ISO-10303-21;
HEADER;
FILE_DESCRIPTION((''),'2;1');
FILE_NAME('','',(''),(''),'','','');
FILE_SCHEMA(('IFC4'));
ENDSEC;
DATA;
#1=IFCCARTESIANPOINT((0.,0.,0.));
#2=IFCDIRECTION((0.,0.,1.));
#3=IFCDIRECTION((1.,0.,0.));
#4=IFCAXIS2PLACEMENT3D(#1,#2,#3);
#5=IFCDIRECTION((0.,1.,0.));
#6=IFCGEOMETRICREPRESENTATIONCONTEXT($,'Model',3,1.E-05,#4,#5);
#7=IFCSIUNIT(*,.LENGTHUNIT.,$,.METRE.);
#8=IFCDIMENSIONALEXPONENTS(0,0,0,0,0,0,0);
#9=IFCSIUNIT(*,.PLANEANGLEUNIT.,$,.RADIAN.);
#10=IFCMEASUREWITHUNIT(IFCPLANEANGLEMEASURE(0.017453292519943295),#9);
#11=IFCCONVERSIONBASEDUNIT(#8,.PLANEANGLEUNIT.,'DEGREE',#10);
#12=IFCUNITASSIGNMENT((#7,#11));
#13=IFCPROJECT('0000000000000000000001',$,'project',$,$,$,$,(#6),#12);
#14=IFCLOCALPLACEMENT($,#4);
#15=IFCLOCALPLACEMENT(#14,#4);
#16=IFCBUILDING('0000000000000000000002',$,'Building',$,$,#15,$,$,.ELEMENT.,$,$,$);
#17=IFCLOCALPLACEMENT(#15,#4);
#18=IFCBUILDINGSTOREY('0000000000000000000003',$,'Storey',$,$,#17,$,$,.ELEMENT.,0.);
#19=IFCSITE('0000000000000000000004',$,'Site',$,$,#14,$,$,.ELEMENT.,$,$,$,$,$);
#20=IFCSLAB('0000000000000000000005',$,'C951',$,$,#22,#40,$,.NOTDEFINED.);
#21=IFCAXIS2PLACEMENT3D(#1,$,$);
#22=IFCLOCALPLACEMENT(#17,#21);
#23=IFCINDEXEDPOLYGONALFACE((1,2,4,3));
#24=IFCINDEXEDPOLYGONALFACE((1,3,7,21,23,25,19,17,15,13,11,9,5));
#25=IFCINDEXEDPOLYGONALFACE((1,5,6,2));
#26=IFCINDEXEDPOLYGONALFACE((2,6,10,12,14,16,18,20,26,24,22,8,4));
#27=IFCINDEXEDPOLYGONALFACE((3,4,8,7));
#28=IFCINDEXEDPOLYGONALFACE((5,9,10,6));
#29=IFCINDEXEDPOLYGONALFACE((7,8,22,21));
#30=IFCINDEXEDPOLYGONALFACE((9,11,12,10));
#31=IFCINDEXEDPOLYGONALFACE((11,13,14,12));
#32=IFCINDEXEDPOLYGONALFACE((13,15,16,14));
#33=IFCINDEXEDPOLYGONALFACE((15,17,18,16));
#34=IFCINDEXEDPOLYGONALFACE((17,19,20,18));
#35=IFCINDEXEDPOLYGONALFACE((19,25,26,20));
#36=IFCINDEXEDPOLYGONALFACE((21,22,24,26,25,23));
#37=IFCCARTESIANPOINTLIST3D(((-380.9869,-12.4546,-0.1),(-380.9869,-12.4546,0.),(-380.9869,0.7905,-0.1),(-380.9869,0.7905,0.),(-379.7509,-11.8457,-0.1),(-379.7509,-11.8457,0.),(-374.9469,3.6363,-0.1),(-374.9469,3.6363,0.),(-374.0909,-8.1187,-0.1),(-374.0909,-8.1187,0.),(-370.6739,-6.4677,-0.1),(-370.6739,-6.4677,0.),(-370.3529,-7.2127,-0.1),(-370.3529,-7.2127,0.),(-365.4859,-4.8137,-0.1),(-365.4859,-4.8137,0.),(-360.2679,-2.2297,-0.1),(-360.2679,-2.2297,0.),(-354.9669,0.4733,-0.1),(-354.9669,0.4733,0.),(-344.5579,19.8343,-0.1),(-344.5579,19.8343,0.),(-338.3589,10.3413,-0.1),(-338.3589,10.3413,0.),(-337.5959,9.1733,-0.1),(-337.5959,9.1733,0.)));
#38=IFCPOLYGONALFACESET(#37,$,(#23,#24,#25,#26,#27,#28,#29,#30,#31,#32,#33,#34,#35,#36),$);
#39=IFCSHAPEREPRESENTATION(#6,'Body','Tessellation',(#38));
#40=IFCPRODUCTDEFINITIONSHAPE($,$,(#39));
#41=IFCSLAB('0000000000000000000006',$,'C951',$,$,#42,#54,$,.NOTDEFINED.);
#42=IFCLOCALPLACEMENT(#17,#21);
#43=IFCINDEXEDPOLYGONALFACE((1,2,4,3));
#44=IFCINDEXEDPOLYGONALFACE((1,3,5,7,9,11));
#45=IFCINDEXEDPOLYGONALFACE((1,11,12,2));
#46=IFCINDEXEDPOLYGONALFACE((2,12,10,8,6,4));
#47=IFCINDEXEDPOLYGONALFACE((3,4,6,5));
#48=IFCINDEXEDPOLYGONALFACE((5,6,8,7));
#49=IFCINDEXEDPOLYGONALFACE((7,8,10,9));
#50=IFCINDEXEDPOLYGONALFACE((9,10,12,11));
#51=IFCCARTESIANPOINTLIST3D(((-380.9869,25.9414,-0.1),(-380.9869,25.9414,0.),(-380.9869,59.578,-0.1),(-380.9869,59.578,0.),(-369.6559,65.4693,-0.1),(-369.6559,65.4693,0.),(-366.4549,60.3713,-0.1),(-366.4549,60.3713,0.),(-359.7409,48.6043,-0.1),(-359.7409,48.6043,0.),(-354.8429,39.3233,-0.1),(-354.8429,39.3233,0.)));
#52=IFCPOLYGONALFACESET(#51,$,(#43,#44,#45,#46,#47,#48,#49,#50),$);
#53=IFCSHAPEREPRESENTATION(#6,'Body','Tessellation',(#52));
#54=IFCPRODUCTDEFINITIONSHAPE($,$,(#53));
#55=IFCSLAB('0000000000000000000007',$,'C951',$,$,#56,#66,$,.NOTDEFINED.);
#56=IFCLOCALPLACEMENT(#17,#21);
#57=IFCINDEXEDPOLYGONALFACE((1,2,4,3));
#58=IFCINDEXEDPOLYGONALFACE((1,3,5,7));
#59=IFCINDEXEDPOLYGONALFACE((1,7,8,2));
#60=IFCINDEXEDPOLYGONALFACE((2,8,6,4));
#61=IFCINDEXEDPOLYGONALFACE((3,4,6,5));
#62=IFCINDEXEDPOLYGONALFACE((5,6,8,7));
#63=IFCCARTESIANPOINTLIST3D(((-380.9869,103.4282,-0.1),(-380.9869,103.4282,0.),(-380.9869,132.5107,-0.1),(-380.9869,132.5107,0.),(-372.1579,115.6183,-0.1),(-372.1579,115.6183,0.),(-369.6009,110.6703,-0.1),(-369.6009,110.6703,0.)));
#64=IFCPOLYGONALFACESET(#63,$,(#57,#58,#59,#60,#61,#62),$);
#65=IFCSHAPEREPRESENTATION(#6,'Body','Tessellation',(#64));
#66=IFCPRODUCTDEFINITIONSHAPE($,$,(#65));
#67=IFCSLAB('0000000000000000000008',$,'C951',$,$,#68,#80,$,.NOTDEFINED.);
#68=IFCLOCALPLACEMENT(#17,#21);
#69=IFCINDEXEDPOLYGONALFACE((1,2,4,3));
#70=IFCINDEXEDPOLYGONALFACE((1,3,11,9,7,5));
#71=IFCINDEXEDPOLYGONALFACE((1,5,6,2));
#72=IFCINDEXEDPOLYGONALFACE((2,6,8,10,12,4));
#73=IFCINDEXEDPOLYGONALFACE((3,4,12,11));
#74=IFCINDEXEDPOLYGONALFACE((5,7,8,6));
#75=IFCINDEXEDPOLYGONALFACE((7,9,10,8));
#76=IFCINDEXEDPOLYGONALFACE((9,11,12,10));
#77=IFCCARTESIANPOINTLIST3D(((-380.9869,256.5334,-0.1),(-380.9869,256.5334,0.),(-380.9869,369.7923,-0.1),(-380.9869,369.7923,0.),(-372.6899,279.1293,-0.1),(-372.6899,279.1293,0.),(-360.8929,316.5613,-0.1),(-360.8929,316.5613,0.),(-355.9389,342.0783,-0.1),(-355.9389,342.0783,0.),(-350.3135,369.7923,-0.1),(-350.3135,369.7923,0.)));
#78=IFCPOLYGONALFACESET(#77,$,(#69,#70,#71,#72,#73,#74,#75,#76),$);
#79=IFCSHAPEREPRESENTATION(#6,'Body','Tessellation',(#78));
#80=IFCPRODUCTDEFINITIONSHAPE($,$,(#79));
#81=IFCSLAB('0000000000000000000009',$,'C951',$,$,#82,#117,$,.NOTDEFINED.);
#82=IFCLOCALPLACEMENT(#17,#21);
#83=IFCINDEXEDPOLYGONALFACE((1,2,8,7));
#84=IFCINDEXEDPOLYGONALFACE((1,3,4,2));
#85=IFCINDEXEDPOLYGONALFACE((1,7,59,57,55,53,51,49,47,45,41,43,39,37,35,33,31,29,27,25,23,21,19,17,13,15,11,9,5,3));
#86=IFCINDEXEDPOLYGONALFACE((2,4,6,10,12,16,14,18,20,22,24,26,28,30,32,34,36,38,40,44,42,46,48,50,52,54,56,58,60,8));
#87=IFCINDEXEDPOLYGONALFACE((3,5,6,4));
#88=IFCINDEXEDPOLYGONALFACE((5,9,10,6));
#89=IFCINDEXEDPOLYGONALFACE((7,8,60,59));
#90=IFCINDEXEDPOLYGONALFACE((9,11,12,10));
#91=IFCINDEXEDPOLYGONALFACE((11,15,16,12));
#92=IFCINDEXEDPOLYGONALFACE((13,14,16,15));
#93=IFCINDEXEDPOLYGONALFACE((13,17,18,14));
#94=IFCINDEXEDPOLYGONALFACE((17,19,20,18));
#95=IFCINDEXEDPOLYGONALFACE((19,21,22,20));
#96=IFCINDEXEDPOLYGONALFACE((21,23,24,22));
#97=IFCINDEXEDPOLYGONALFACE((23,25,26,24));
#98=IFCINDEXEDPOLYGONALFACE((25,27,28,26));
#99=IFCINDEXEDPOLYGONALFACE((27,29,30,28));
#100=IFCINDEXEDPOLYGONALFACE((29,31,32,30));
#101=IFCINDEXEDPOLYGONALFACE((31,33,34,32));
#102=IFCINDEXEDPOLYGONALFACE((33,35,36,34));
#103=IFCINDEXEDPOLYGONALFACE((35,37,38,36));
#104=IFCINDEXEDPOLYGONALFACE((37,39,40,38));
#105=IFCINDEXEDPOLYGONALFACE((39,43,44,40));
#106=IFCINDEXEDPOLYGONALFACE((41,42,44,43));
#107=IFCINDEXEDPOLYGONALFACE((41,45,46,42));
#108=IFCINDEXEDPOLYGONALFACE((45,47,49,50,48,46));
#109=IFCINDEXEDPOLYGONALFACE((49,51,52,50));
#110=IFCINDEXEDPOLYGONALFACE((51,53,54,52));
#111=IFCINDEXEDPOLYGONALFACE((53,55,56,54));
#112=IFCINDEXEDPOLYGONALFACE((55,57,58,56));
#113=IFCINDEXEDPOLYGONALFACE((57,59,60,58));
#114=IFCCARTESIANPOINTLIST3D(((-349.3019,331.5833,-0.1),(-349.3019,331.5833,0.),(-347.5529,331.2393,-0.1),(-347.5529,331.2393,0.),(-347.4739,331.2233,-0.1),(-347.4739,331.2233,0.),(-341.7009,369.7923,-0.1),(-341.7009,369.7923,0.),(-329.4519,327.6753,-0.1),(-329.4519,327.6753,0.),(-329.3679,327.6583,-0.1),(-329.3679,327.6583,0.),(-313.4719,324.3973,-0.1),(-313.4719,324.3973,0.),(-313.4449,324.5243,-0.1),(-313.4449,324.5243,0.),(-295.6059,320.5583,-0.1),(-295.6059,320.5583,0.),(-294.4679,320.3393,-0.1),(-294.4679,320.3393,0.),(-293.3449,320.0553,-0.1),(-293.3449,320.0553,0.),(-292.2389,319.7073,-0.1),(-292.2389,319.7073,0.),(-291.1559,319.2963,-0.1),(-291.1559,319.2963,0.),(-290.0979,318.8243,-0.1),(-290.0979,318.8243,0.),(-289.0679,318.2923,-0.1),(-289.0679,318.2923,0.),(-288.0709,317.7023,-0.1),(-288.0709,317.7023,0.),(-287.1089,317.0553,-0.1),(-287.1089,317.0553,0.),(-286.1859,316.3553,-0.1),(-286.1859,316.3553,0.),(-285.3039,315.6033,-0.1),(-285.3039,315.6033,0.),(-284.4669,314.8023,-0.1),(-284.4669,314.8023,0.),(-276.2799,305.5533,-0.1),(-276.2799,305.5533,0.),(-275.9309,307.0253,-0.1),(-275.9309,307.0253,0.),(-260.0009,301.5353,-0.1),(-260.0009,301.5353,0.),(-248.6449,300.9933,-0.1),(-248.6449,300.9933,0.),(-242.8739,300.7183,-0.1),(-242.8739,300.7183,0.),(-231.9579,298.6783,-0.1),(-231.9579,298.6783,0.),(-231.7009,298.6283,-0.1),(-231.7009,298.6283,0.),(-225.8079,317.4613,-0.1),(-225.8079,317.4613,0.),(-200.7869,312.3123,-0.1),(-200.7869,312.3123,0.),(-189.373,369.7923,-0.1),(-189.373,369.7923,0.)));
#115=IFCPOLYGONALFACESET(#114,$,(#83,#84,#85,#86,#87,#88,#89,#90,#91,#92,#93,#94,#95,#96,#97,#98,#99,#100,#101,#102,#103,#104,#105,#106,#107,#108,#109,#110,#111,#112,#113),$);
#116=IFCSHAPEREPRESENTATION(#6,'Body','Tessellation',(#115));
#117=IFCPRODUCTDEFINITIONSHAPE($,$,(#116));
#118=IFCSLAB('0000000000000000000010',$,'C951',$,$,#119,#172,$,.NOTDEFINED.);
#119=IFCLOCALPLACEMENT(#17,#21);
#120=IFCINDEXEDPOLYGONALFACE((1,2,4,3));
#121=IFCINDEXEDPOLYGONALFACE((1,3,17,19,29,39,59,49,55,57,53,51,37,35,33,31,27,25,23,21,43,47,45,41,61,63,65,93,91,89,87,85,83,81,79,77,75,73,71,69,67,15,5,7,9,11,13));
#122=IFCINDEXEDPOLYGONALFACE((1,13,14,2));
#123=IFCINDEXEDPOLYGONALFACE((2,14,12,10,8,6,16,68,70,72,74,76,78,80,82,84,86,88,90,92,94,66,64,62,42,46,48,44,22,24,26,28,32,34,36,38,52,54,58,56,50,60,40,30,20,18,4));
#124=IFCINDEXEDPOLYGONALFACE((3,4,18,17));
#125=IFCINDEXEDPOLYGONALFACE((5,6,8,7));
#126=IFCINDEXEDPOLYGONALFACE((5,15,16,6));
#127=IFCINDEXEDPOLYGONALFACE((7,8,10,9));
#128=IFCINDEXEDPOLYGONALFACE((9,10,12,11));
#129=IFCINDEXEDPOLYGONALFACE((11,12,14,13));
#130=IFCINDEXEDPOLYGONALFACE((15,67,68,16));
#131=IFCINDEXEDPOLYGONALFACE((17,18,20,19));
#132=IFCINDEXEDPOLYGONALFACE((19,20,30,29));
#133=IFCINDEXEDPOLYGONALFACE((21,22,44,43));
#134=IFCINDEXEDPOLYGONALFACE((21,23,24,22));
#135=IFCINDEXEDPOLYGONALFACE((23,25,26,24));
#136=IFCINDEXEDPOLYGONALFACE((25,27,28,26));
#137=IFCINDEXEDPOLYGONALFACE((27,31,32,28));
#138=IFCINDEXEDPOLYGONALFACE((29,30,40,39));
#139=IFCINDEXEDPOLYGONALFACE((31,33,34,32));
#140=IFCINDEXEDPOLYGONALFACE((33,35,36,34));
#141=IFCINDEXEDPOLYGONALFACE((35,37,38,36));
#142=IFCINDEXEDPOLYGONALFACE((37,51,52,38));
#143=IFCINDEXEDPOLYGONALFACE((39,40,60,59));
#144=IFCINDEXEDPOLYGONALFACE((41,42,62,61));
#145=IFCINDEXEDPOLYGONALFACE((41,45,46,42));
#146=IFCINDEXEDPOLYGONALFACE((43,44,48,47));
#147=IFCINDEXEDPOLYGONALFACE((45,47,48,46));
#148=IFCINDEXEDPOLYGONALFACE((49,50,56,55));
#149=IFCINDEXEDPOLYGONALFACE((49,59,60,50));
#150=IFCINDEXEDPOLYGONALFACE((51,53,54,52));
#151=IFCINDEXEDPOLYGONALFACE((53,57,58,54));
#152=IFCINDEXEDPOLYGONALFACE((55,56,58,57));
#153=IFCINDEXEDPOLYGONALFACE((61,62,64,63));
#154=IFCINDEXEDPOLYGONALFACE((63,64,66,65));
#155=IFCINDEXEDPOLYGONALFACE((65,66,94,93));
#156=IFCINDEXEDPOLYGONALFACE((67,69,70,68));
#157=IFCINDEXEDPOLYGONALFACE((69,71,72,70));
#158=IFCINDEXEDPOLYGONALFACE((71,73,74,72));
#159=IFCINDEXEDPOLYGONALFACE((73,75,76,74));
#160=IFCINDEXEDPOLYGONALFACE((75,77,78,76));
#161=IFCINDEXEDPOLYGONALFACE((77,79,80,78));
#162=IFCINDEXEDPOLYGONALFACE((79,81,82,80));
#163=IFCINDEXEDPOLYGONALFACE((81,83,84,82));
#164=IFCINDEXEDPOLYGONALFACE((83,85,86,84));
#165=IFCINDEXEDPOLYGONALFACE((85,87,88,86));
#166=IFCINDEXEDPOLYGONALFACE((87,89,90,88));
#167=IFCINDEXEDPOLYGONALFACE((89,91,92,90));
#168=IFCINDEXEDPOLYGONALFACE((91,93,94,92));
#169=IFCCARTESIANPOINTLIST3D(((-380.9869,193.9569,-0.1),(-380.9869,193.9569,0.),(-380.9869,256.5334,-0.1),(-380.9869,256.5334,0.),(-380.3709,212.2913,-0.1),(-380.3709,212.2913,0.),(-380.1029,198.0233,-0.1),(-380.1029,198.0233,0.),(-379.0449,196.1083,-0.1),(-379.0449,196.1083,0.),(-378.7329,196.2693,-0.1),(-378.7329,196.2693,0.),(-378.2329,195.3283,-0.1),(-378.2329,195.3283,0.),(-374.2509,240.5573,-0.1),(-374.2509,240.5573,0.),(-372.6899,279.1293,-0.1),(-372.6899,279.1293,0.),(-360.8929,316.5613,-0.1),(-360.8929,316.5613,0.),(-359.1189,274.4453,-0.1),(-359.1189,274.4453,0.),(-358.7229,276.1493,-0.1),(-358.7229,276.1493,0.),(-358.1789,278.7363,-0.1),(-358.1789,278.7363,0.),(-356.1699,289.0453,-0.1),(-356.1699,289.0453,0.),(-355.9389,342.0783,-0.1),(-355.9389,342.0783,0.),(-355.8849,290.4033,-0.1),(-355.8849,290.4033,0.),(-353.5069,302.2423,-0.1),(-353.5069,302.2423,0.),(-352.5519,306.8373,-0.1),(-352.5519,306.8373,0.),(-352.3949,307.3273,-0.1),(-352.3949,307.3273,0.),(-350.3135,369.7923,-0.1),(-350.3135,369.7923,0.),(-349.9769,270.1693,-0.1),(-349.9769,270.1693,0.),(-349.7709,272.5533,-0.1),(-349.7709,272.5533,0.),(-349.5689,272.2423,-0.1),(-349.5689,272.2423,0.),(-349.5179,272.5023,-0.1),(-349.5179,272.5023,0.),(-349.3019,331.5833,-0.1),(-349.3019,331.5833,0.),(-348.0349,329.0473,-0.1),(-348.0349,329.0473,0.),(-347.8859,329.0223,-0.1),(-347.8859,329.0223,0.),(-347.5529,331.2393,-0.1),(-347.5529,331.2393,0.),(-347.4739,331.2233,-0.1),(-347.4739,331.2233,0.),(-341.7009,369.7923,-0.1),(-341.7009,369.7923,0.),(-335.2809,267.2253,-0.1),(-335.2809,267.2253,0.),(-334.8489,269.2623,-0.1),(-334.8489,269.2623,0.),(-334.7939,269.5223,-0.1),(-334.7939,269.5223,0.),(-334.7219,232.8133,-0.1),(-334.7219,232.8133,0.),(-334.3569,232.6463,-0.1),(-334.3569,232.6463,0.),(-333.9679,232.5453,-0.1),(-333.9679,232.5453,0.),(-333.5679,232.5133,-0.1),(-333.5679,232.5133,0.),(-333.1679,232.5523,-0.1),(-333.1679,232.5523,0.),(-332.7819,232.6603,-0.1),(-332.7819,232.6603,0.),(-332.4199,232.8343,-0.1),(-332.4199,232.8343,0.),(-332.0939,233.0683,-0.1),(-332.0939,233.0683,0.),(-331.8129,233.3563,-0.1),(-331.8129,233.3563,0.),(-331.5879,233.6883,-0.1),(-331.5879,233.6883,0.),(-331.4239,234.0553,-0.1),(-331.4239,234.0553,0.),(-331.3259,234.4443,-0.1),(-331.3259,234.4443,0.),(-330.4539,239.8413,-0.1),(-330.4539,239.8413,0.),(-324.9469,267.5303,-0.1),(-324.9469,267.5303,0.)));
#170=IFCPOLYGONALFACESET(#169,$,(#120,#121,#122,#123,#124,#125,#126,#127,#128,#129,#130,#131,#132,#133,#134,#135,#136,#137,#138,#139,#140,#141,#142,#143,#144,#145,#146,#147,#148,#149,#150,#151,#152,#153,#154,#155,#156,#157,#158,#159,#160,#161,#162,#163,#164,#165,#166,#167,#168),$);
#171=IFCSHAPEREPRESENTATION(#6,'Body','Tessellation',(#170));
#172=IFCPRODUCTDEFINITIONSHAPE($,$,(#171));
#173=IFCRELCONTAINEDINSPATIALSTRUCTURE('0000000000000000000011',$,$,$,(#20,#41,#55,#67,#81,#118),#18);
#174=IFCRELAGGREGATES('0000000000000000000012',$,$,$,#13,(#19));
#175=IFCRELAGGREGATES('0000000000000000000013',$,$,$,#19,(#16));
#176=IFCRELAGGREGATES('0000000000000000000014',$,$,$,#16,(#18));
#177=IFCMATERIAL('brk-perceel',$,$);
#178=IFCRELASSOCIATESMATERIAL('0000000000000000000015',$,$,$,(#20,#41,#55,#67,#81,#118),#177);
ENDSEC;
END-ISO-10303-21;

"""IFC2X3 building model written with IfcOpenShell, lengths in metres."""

from ifc_helpers import new_model, entity, si_unit, converted_unit, direction, frame, origin_with_axes, place, context, project, spatial, polyline, outline, extrude, material, element, save


model = new_model("IFC2X3")

# Units and contexts
model_context = context("Model", 3, precision=1e-05, world=origin_with_axes(), true_north=direction((0.0, 1.0, 0.0)))
ifc_project = project(units=[si_unit("LENGTHUNIT", "METRE"), converted_unit("PLANEANGLEUNIT", "DEGREE", entity("IfcPlaneAngleMeasure", 0.017453292519943295), si_unit("PLANEANGLEUNIT", "RADIAN"), dimensions=[0, 0, 0, 0, 0, 0, 0])], contexts=[model_context])

# Site, building, storey
site_placement = place(None, origin_with_axes())
site = spatial("IfcSite", under=ifc_project, at=site_placement, Name="Site", CompositionType="ELEMENT")
building_placement = place(site_placement, origin_with_axes())
building = spatial("IfcBuilding", under=site, at=building_placement, Name="Building", CompositionType="ELEMENT")
storey_placement = place(building_placement, origin_with_axes())
storey = spatial("IfcBuildingStorey", under=building, at=storey_placement, Name="Storey", CompositionType="ELEMENT", Elevation=0.0)

# Slabs
ifc_material = material(Name="brk-perceel")
slab_1_placement = place(storey_placement, frame((0.0, 0.0, -0.1), z_axis=(0.0, 0.0, 1.0), x_axis=(1.0, 0.0, 0.0)))
element("IfcSlab", 1, at=slab_1_placement, inside=storey, material=ifc_material, Name="C951", PredefinedType="NOTDEFINED", context=model_context, shape_type="SweptSolid", body=[
    extrude(outline(polyline([(-374.9469, 3.6363), (-344.5579, 19.8343), (-338.3589, 10.3413), (-337.5959, 9.1733), (-354.9669, 0.4733), (-360.2679, -2.2297), (-365.4859, -4.8137), (-370.3529, -7.2127), (-370.6739, -6.4677), (-374.0909, -8.1187), (-379.7509, -11.8457), (-380.9869, -12.4546), (-380.9869, 0.7905), (-374.9469, 3.6363)])), origin_with_axes(), (0.0, 0.0, 1.0), 0.1),
])
slab_2_placement = place(storey_placement, frame((0.0, 0.0, -0.1), z_axis=(0.0, 0.0, 1.0), x_axis=(1.0, 0.0, 0.0)))
element("IfcSlab", 2, at=slab_2_placement, inside=storey, material=ifc_material, Name="C951", PredefinedType="NOTDEFINED", context=model_context, shape_type="SweptSolid", body=[
    extrude(outline(polyline([(-369.6559, 65.4693), (-366.4549, 60.3713), (-359.7409, 48.6043), (-354.8429, 39.3233), (-380.9869, 25.9414), (-380.9869, 59.578), (-369.6559, 65.4693)])), origin_with_axes(), (0.0, 0.0, 1.0), 0.1),
])
slab_3_placement = place(storey_placement, frame((0.0, 0.0, -0.1), z_axis=(0.0, 0.0, 1.0), x_axis=(1.0, 0.0, 0.0)))
element("IfcSlab", 3, at=slab_3_placement, inside=storey, material=ifc_material, Name="C951", PredefinedType="NOTDEFINED", context=model_context, shape_type="SweptSolid", body=[
    extrude(outline(polyline([(-372.1579, 115.6183), (-369.6009, 110.6703), (-380.9869, 103.4282), (-380.9869, 132.5107), (-372.1579, 115.6183)])), origin_with_axes(), (0.0, 0.0, 1.0), 0.1),
])
slab_4_placement = place(storey_placement, frame((0.0, 0.0, -0.1), z_axis=(0.0, 0.0, 1.0), x_axis=(1.0, 0.0, 0.0)))
element("IfcSlab", 4, at=slab_4_placement, inside=storey, material=ifc_material, Name="C951", PredefinedType="NOTDEFINED", context=model_context, shape_type="SweptSolid", body=[
    extrude(outline(polyline([(-355.9389, 342.0783), (-360.8929, 316.5613), (-372.6899, 279.1293), (-380.9869, 256.5334), (-380.9869, 369.7923), (-350.3135, 369.7923), (-355.9389, 342.0783)])), origin_with_axes(), (0.0, 0.0, 1.0), 0.1),
])
slab_5_placement = place(storey_placement, frame((0.0, 0.0, -0.1), z_axis=(0.0, 0.0, 1.0), x_axis=(1.0, 0.0, 0.0)))
element("IfcSlab", 5, at=slab_5_placement, inside=storey, material=ifc_material, Name="C951", PredefinedType="NOTDEFINED", context=model_context, shape_type="SweptSolid", body=[
    extrude(outline(polyline([(-200.7869, 312.3123), (-225.8079, 317.4613), (-231.7009, 298.6283), (-231.9579, 298.6783), (-242.8739, 300.7183), (-248.6449, 300.9933), (-260.0009, 301.5353), (-276.2799, 305.5533), (-275.9309, 307.0253), (-284.4669, 314.8023), (-285.3039, 315.6033), (-286.1859, 316.3553), (-287.1089, 317.0553), (-288.0709, 317.7023), (-289.0679, 318.2923), (-290.0979, 318.8243), (-291.1559, 319.2963), (-292.2389, 319.7073), (-293.3449, 320.0553), (-294.4679, 320.3393), (-295.6059, 320.5583), (-313.4719, 324.3973), (-313.4449, 324.5243), (-329.3679, 327.6583), (-329.4519, 327.6753), (-347.4739, 331.2233), (-347.5529, 331.2393), (-349.3019, 331.5833), (-341.7009, 369.7923), (-189.373, 369.7923), (-200.7869, 312.3123)])), origin_with_axes(), (0.0, 0.0, 1.0), 0.1),
])
slab_6_placement = place(storey_placement, frame((0.0, 0.0, -0.1), z_axis=(0.0, 0.0, 1.0), x_axis=(1.0, 0.0, 0.0)))
element("IfcSlab", 6, at=slab_6_placement, inside=storey, material=ifc_material, Name="C951", PredefinedType="NOTDEFINED", context=model_context, shape_type="SweptSolid", body=[
    extrude(outline(polyline([(-349.3019, 331.5833), (-347.5529, 331.2393), (-347.4739, 331.2233), (-347.8859, 329.0223), (-348.0349, 329.0473), (-352.3949, 307.3273), (-352.5519, 306.8373), (-353.5069, 302.2423), (-355.8849, 290.4033), (-356.1699, 289.0453), (-358.1789, 278.7363), (-358.7229, 276.1493), (-359.1189, 274.4453), (-349.7709, 272.5533), (-349.5179, 272.5023), (-349.5689, 272.2423), (-349.9769, 270.1693), (-335.2809, 267.2253), (-334.8489, 269.2623), (-334.7939, 269.5223), (-324.9469, 267.5303), (-330.4539, 239.8413), (-331.3259, 234.4443), (-331.4239, 234.0553), (-331.5879, 233.6883), (-331.8129, 233.3563), (-332.0939, 233.0683), (-332.4199, 232.8343), (-332.7819, 232.6603), (-333.1679, 232.5523), (-333.5679, 232.5133), (-333.9679, 232.5453), (-334.3569, 232.6463), (-334.7219, 232.8133), (-374.2509, 240.5573), (-380.3709, 212.2913), (-380.1029, 198.0233), (-379.0449, 196.1083), (-378.7329, 196.2693), (-378.2329, 195.3283), (-380.9869, 193.9569), (-380.9869, 256.5334), (-372.6899, 279.1293), (-360.8929, 316.5613), (-355.9389, 342.0783), (-350.3135, 369.7923), (-341.7009, 369.7923), (-349.3019, 331.5833)])), origin_with_axes(), (0.0, 0.0, 1.0), 0.1),
])

save(model, "model.ifc")
